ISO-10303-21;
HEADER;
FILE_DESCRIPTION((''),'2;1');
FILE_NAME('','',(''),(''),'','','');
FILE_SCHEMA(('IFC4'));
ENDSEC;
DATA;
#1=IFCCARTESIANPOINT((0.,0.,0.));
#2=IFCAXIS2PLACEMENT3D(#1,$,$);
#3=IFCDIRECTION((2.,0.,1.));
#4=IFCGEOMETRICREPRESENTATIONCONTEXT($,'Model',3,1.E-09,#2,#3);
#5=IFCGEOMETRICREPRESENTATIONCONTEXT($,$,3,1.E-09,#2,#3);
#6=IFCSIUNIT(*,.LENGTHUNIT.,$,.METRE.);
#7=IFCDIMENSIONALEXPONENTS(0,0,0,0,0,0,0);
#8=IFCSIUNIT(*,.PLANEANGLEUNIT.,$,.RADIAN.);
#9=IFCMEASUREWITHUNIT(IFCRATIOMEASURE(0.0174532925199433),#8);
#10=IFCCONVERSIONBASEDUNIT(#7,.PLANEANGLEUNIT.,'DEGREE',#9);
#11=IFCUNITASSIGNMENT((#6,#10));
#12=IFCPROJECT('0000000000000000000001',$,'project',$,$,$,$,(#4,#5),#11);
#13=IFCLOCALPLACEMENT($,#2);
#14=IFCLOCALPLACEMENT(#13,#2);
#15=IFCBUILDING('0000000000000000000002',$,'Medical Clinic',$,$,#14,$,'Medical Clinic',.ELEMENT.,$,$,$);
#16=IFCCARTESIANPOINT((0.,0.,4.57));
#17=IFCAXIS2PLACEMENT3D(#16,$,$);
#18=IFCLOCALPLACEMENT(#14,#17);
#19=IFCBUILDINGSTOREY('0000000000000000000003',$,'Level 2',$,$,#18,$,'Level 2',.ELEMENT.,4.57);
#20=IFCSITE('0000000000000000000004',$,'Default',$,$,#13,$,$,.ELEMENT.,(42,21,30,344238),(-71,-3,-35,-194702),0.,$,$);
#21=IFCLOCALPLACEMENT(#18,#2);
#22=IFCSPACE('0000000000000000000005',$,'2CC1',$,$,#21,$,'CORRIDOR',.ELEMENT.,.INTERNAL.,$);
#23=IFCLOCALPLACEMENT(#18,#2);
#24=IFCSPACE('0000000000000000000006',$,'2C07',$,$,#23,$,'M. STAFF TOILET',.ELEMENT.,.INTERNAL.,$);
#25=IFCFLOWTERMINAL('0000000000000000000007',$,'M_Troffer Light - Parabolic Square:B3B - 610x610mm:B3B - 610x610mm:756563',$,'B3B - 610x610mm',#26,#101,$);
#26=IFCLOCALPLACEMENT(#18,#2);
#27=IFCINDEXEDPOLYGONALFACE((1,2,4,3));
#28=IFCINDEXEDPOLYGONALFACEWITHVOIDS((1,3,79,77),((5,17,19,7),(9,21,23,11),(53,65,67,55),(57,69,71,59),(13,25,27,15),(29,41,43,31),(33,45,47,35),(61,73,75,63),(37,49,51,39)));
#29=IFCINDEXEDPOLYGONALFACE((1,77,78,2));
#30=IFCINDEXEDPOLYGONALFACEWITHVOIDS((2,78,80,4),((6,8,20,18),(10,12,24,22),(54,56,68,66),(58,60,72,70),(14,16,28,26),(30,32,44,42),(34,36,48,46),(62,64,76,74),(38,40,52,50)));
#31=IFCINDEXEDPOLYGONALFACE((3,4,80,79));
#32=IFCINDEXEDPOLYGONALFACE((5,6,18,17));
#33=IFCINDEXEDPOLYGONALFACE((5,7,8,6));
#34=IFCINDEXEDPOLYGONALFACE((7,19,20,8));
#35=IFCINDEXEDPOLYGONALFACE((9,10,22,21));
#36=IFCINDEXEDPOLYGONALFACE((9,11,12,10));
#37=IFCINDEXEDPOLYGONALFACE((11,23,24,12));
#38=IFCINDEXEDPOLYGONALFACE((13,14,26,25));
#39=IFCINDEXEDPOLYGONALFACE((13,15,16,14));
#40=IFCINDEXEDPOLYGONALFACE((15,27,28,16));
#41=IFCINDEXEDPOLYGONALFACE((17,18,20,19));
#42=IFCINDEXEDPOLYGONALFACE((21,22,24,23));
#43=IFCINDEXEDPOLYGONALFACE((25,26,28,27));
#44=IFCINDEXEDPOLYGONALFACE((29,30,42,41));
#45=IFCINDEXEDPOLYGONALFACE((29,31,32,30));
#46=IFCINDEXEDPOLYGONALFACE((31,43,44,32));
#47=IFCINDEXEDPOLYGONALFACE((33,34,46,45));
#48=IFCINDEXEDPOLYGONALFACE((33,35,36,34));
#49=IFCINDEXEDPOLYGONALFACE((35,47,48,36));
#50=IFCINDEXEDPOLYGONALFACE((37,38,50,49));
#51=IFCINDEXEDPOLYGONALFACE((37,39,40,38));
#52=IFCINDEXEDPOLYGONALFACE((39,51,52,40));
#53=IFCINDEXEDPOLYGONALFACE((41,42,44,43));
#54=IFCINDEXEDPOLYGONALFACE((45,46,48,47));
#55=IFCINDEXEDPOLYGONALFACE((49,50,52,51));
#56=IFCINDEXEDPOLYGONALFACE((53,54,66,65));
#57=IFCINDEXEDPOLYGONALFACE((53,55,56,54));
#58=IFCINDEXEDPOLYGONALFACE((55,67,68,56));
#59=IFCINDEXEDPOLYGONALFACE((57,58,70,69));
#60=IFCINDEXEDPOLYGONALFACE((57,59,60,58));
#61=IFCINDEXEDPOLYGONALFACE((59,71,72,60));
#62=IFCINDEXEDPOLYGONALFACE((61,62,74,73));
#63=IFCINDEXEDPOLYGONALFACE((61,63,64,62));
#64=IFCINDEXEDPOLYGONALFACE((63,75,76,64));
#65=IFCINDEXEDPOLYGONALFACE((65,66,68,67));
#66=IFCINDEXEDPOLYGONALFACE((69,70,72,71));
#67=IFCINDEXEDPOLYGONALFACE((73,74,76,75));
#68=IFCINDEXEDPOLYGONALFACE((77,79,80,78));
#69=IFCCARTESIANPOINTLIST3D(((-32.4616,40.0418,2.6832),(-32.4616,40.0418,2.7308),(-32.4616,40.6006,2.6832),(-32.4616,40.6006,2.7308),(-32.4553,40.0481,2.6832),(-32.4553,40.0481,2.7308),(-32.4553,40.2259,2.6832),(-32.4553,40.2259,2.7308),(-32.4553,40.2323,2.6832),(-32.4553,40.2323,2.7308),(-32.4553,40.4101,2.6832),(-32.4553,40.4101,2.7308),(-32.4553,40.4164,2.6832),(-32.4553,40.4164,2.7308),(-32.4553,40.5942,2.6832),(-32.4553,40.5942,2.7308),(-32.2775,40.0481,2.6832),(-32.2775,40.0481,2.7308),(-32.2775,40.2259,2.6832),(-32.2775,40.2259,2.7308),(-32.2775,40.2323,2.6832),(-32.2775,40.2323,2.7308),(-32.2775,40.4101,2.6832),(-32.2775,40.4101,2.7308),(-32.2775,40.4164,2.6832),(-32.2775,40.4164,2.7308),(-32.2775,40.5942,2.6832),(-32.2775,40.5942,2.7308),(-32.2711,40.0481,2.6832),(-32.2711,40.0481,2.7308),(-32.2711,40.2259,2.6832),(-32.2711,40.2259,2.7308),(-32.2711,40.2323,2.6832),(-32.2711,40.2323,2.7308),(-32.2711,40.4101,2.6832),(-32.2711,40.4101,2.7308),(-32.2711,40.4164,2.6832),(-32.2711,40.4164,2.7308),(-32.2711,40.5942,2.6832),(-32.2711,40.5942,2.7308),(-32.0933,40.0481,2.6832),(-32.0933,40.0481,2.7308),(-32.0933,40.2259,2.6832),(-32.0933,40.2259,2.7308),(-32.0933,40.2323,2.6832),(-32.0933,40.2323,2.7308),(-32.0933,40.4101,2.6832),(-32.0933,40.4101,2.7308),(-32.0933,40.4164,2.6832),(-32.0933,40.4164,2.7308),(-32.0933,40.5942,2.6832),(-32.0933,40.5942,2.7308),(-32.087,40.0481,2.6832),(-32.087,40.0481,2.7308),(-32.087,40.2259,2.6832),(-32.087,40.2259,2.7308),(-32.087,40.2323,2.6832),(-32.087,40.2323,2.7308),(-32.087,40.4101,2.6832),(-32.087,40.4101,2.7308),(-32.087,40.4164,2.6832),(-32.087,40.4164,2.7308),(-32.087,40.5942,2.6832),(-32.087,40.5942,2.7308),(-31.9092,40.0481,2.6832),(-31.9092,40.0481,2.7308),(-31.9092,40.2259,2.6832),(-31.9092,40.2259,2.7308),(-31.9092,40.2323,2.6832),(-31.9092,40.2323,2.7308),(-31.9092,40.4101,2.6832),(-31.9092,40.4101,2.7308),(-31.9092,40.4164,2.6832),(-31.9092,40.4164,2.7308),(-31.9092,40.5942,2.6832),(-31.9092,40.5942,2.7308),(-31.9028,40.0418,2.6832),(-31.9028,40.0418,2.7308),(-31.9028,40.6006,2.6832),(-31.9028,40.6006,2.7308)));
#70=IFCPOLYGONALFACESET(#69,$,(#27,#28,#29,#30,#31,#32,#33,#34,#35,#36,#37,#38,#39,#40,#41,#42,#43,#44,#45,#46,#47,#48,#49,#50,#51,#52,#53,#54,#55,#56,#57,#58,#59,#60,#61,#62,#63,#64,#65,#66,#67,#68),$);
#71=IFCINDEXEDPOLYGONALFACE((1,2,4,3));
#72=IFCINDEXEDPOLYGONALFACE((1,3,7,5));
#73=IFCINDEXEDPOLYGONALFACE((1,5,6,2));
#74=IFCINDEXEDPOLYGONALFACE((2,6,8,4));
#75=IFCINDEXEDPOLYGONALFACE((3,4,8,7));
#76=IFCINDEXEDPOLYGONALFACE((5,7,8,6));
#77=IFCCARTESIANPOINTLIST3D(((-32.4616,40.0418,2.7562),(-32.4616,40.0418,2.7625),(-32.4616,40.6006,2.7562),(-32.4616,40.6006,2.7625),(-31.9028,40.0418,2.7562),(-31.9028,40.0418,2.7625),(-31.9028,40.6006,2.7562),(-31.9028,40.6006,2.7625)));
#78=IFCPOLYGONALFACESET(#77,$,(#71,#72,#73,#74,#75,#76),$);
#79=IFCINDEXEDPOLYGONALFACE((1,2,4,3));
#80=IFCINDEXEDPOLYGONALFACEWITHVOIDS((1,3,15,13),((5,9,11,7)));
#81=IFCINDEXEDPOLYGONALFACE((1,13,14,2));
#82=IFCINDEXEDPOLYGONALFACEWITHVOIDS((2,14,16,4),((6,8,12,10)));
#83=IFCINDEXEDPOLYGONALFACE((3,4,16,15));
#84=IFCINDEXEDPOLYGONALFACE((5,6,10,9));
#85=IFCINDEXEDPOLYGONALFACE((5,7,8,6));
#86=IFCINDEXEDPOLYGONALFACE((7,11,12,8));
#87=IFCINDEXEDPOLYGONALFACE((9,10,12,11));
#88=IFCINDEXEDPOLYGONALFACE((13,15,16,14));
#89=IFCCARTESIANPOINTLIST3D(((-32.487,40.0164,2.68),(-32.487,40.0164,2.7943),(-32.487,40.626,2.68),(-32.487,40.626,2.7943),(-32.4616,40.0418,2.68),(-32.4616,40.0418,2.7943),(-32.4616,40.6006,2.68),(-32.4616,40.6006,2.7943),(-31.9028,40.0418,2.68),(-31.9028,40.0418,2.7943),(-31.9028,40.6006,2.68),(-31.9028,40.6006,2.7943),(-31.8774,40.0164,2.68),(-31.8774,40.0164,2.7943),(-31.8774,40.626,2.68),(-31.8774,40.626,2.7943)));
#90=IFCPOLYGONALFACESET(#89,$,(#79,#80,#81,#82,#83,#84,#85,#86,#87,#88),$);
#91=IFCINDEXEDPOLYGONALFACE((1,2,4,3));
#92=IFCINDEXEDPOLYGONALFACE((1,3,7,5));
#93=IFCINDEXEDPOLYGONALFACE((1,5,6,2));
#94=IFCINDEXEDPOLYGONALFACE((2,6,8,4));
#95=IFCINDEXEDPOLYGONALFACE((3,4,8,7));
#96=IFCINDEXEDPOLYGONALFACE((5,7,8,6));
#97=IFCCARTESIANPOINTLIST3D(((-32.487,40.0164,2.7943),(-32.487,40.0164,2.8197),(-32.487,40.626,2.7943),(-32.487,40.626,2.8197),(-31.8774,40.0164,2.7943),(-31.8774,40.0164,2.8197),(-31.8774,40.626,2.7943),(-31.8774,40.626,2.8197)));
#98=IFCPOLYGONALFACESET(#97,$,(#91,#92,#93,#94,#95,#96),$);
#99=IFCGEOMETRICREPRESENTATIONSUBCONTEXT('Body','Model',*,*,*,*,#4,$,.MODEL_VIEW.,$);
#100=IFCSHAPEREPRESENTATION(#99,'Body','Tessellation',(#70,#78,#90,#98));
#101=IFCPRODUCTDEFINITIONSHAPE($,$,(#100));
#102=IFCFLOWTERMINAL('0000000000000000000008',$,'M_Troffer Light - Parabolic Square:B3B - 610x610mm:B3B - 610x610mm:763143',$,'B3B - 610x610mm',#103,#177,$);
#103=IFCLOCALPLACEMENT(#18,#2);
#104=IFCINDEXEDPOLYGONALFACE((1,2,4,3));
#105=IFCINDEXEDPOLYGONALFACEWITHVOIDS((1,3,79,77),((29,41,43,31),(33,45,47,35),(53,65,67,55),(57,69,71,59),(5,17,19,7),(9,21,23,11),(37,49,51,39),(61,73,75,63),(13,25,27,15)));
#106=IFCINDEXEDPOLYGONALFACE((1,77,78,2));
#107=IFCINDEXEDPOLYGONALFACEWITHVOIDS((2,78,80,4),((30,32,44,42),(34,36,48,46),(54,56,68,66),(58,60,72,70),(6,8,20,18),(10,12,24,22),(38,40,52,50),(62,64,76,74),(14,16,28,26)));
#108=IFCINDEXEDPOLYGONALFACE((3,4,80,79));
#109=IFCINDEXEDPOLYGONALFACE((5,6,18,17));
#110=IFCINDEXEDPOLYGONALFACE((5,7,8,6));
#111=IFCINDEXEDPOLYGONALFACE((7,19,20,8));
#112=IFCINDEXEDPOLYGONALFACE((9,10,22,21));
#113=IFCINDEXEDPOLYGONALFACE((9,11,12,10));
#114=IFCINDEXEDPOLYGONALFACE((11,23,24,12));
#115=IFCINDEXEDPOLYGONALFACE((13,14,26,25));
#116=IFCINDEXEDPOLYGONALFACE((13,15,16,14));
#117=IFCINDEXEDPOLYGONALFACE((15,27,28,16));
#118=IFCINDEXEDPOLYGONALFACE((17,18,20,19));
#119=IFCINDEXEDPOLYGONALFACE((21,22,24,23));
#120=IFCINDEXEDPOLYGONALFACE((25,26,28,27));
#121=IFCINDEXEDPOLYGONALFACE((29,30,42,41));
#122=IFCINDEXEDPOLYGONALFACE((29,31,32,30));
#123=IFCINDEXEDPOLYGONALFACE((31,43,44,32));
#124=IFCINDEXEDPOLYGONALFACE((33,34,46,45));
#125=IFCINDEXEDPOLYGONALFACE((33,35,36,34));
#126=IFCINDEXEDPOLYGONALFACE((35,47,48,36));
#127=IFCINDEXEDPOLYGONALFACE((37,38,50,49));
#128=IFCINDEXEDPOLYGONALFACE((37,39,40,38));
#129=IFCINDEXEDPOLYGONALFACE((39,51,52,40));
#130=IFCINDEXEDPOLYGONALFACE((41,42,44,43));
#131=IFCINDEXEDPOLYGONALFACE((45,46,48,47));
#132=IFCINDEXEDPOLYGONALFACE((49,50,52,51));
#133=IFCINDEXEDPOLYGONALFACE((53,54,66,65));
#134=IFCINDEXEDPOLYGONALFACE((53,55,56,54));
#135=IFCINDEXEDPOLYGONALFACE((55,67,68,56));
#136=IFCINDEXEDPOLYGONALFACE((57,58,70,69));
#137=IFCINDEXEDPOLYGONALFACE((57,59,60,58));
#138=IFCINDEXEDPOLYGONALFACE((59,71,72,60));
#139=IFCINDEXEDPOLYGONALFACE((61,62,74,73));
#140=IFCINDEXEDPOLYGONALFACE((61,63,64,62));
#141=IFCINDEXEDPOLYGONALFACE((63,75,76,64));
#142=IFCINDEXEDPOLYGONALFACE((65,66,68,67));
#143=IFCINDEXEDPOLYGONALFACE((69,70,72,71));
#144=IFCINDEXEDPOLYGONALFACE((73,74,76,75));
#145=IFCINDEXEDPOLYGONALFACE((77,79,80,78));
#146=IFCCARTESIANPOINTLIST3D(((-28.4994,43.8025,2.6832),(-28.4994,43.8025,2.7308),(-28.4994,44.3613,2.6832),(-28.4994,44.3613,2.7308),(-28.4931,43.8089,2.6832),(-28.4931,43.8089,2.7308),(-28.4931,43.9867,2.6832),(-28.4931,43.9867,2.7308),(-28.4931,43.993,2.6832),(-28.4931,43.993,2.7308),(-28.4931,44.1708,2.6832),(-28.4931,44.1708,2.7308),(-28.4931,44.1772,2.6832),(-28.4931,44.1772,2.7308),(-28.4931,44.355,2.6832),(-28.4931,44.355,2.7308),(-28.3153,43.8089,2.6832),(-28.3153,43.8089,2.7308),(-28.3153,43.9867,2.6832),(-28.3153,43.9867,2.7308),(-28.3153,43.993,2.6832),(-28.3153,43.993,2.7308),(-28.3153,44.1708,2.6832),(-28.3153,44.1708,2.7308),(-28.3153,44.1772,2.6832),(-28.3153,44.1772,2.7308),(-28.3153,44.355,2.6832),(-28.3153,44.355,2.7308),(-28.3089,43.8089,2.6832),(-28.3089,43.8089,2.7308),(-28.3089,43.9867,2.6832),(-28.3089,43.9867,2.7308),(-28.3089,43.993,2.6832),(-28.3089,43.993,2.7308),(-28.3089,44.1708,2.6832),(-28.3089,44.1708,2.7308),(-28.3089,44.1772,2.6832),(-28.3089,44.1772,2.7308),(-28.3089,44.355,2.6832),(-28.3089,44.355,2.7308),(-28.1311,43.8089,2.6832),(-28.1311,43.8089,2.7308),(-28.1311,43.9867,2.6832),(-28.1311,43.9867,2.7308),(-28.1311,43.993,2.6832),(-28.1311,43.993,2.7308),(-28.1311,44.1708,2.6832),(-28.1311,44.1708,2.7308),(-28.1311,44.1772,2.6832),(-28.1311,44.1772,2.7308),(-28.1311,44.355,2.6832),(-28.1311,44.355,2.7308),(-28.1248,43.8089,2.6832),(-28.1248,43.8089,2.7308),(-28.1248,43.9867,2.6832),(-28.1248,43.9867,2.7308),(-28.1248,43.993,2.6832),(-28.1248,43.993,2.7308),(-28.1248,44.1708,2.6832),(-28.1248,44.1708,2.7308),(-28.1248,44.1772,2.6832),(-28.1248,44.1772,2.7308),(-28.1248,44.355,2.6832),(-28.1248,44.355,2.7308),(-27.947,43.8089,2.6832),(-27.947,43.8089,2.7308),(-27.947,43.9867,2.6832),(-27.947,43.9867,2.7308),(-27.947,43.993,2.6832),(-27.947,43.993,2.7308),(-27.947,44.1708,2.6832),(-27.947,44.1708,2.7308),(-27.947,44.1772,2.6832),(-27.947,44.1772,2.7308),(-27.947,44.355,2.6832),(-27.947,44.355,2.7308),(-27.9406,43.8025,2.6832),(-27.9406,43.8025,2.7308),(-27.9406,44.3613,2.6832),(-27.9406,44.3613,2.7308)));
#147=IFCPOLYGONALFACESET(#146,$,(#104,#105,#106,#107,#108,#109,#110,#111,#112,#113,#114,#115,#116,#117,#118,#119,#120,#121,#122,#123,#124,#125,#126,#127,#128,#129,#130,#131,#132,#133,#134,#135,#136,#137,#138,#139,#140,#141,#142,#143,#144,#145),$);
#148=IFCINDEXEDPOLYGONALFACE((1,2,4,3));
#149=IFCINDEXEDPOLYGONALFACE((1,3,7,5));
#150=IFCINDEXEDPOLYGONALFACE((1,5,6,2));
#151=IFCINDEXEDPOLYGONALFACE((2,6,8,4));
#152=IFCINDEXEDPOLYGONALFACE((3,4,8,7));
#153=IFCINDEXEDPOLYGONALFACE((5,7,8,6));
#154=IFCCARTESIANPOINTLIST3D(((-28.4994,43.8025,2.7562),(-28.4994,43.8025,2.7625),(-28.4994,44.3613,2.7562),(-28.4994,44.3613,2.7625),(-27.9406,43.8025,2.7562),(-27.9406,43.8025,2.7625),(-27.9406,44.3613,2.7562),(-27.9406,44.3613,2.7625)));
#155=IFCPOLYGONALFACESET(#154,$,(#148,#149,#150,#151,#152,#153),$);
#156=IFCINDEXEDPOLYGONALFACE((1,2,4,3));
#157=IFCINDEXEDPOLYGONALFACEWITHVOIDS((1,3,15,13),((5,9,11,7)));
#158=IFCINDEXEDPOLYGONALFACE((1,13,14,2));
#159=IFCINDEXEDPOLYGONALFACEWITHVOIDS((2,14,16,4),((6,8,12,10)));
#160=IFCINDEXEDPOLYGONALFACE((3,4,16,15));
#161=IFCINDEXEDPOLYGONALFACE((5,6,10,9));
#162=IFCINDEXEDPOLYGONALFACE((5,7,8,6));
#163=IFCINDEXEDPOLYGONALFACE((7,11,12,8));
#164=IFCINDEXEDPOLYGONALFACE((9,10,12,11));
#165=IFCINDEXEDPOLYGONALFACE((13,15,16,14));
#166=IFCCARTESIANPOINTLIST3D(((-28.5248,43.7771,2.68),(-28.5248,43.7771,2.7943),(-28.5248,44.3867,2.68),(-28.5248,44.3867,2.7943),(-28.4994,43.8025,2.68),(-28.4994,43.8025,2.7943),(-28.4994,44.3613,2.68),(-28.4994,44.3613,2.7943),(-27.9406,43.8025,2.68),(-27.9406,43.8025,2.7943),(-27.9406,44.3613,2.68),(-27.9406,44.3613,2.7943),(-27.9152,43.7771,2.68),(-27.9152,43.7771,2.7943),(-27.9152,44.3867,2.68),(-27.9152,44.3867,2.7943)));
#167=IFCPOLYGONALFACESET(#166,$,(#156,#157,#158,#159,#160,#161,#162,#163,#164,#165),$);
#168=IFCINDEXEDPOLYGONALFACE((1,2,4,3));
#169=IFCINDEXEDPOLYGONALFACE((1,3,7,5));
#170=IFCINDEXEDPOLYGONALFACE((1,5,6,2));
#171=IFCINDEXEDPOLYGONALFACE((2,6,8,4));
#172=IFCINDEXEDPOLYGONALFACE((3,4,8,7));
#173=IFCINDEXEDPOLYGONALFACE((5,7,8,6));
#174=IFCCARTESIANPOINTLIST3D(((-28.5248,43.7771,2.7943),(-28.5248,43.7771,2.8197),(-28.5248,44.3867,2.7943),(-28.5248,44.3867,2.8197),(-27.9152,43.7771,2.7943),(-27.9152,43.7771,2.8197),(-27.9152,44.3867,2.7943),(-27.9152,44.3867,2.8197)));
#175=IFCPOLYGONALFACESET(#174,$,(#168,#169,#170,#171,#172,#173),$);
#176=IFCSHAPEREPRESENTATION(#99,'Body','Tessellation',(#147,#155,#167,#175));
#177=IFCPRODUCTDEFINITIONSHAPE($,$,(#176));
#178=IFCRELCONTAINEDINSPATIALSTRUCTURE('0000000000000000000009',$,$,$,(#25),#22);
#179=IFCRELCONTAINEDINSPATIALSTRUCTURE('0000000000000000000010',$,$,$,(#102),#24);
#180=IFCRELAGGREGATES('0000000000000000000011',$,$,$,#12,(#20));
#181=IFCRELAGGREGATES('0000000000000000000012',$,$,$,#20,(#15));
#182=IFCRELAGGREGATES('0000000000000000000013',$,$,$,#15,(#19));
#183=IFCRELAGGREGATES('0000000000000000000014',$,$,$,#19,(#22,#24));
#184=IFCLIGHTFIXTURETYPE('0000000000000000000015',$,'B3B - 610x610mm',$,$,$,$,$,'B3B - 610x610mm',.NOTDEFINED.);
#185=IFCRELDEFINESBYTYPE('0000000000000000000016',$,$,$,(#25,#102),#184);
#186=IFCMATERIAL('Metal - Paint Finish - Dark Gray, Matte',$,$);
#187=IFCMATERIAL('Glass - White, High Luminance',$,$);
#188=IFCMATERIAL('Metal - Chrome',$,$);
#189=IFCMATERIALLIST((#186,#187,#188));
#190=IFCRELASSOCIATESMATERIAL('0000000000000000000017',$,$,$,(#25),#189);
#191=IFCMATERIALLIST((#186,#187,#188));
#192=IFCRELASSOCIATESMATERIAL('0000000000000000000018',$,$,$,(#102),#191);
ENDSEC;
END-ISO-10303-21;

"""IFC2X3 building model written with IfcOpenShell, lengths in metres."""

from ifc_helpers import new_model, entity, si_unit, converted_unit, direction, frame, origin, origin_2d_with_axis, place, context, subcontext, project, spatial, polyline, rectangle, outline, extrude, source, transform, mapped, material, material_list, type_object, type_shapes, element, save


model = new_model("IFC2X3")

# Units and contexts
model_context = context("Model", 3, precision=1e-09, world=origin(), true_north=direction((2.0, 0.0, 1.0)))
context_of_model = context(None, 3, precision=1e-09, world=origin(), true_north=direction((2.0, 0.0, 1.0)))
body_context = subcontext(model_context, "Body", "Model", "MODEL_VIEW")
ifc_project = project(units=[si_unit("LENGTHUNIT", "METRE"), converted_unit("PLANEANGLEUNIT", "DEGREE", entity("IfcRatioMeasure", 0.0174532925199433), si_unit("PLANEANGLEUNIT", "RADIAN"), dimensions=[0, 0, 0, 0, 0, 0, 0])], contexts=[model_context, context_of_model])

# Site, building, storey, space
site_placement = place(None, origin())
site = spatial("IfcSite", under=ifc_project, at=site_placement, Name="Default", CompositionType="ELEMENT", RefLatitude=(42, 21, 30, 344238), RefLongitude=(-71, -3, -35, -194702), RefElevation=0.0)
building_placement = place(site_placement, origin())
building = spatial("IfcBuilding", under=site, at=building_placement, Name="Medical Clinic", LongName="Medical Clinic", CompositionType="ELEMENT")
storey_placement = place(building_placement, frame((0.0, 0.0, 4.57)))
storey = spatial("IfcBuildingStorey", under=building, at=storey_placement, Name="Level 2", LongName="Level 2", CompositionType="ELEMENT", Elevation=4.57)
space_1_placement = place(storey_placement, origin())
space_1 = spatial("IfcSpace", under=storey, at=space_1_placement, Name="2CC1", LongName="CORRIDOR", CompositionType="ELEMENT", InteriorOrExteriorSpace="INTERNAL")

# Shared definitions
ifc_material_1 = material(Name="Metal - Paint Finish - Dark Gray, Matte")
ifc_material_2 = material(Name="Glass - White, High Luminance")
ifc_material_3 = material(Name="Metal - Chrome")

# Flow terminal
ifc_material_list_1 = material_list([ifc_material_1, ifc_material_2, ifc_material_3])
light_fixture_type_1 = type_object("IfcLightFixtureType", Name="B3B - 610x610mm", ElementType="B3B - 610x610mm", PredefinedType="NOTDEFINED")
shared_shape_1 = source(origin(), body_context, "Body", "SweptSolid", [
    extrude(outline(polyline([(-0.2794, -0.2794), (0.2794, -0.2794), (0.2794, 0.2794), (-0.2794, 0.2794), (-0.2794, -0.2794)]), holes=[polyline([(-0.0952, 0.0953), (-0.273, 0.0953), (-0.273, 0.2731), (-0.0952, 0.2731), (-0.0952, 0.0953)]), polyline([(0.2731, 0.0953), (0.0953, 0.0953), (0.0953, 0.2731), (0.2731, 0.2731), (0.2731, 0.0953)]), polyline([(-0.0889, 0.2731), (0.0889, 0.2731), (0.0889, 0.0953), (-0.0889, 0.0953), (-0.0889, 0.2731)]), polyline([(0.2731, -0.273), (0.0953, -0.273), (0.0953, -0.0952), (0.2731, -0.0952), (0.2731, -0.273)]), polyline([(0.0889, -0.273), (-0.0889, -0.273), (-0.0889, -0.0952), (0.0889, -0.0952), (0.0889, -0.273)]), polyline([(-0.0952, -0.273), (-0.273, -0.273), (-0.273, -0.0952), (-0.0952, -0.0952), (-0.0952, -0.273)]), polyline([(-0.0952, -0.0889), (-0.273, -0.0889), (-0.273, 0.0889), (-0.0952, 0.0889), (-0.0952, -0.0889)]), polyline([(0.0889, -0.0889), (-0.0889, -0.0889), (-0.0889, 0.0889), (0.0889, 0.0889), (0.0889, -0.0889)]), polyline([(0.2731, -0.0889), (0.0953, -0.0889), (0.0953, 0.0889), (0.2731, 0.0889), (0.2731, -0.0889)])]), frame((0.0, -0.3048, -0.0508), z_axis=(0.0, 0.0, 1.0), x_axis=(-1.0, 0.0, 0.0)), (0.0, 0.0, 1.0), 0.0476),
    extrude(rectangle(XDim=0.5588, YDim=0.5588, at=origin_2d_with_axis()), frame((0.0, -0.3048, -0.0825), z_axis=(0.0, 0.0, 1.0), x_axis=(-1.0, 0.0, 0.0)), (0.0, 0.0, 1.0), 0.0064),
    extrude(outline(polyline([(-0.3048, -0.3048), (0.3048, -0.3048), (0.3048, 0.3048), (-0.3048, 0.3048), (-0.3048, -0.3048)]), holes=[polyline([(0.2794, 0.2794), (0.2794, -0.2794), (-0.2794, -0.2794), (-0.2794, 0.2794), (0.2794, 0.2794)])]), frame((0.0, -0.3048, -0.1143)), (0.0, 0.0, 1.0), 0.1143),
    extrude(rectangle(XDim=0.6096, YDim=0.6096, at=origin_2d_with_axis()), frame((0.0, -0.3048, -0.1397), z_axis=(0.0, 0.0, 1.0), x_axis=(-1.0, 0.0, 0.0)), (0.0, 0.0, 1.0), 0.0254),
])
type_shapes(light_fixture_type_1, [shared_shape_1])
flow_terminal_1_placement = place(space_1_placement, frame((-32.1822, 40.0164, 2.68), z_axis=(0.0, 0.0, -1.0), x_axis=(1.0, 0.0, 0.0)))
element("IfcFlowTerminal", 1, at=flow_terminal_1_placement, inside=space_1, type_object=light_fixture_type_1, material=ifc_material_list_1, Name="M_Troffer Light - Parabolic Square:B3B - 610x610mm:B3B - 610x610mm:756563", ObjectType="B3B - 610x610mm", context=body_context, shape_type="MappedRepresentation", body=[
    mapped(shared_shape_1, transform((0.0, 0.0, 0.0), scale=1.0)),
])

# Shared definitions
space_2_placement = place(storey_placement, origin())
space_2 = spatial("IfcSpace", under=storey, at=space_2_placement, Name="2C07", LongName="M. STAFF TOILET", CompositionType="ELEMENT", InteriorOrExteriorSpace="INTERNAL")

# Flow terminal
ifc_material_list_2 = material_list([ifc_material_1, ifc_material_2, ifc_material_3])
flow_terminal_2_placement = place(space_2_placement, frame((-28.22, 43.7771, 2.68), z_axis=(0.0, 0.0, -1.0), x_axis=(1.0, 0.0, 0.0)))
element("IfcFlowTerminal", 2, at=flow_terminal_2_placement, inside=space_2, type_object=light_fixture_type_1, material=ifc_material_list_2, Name="M_Troffer Light - Parabolic Square:B3B - 610x610mm:B3B - 610x610mm:763143", ObjectType="B3B - 610x610mm", context=body_context, shape_type="MappedRepresentation", body=[
    mapped(shared_shape_1, transform((0.0, 0.0, 0.0), scale=1.0)),
])

save(model, "model.ifc")
